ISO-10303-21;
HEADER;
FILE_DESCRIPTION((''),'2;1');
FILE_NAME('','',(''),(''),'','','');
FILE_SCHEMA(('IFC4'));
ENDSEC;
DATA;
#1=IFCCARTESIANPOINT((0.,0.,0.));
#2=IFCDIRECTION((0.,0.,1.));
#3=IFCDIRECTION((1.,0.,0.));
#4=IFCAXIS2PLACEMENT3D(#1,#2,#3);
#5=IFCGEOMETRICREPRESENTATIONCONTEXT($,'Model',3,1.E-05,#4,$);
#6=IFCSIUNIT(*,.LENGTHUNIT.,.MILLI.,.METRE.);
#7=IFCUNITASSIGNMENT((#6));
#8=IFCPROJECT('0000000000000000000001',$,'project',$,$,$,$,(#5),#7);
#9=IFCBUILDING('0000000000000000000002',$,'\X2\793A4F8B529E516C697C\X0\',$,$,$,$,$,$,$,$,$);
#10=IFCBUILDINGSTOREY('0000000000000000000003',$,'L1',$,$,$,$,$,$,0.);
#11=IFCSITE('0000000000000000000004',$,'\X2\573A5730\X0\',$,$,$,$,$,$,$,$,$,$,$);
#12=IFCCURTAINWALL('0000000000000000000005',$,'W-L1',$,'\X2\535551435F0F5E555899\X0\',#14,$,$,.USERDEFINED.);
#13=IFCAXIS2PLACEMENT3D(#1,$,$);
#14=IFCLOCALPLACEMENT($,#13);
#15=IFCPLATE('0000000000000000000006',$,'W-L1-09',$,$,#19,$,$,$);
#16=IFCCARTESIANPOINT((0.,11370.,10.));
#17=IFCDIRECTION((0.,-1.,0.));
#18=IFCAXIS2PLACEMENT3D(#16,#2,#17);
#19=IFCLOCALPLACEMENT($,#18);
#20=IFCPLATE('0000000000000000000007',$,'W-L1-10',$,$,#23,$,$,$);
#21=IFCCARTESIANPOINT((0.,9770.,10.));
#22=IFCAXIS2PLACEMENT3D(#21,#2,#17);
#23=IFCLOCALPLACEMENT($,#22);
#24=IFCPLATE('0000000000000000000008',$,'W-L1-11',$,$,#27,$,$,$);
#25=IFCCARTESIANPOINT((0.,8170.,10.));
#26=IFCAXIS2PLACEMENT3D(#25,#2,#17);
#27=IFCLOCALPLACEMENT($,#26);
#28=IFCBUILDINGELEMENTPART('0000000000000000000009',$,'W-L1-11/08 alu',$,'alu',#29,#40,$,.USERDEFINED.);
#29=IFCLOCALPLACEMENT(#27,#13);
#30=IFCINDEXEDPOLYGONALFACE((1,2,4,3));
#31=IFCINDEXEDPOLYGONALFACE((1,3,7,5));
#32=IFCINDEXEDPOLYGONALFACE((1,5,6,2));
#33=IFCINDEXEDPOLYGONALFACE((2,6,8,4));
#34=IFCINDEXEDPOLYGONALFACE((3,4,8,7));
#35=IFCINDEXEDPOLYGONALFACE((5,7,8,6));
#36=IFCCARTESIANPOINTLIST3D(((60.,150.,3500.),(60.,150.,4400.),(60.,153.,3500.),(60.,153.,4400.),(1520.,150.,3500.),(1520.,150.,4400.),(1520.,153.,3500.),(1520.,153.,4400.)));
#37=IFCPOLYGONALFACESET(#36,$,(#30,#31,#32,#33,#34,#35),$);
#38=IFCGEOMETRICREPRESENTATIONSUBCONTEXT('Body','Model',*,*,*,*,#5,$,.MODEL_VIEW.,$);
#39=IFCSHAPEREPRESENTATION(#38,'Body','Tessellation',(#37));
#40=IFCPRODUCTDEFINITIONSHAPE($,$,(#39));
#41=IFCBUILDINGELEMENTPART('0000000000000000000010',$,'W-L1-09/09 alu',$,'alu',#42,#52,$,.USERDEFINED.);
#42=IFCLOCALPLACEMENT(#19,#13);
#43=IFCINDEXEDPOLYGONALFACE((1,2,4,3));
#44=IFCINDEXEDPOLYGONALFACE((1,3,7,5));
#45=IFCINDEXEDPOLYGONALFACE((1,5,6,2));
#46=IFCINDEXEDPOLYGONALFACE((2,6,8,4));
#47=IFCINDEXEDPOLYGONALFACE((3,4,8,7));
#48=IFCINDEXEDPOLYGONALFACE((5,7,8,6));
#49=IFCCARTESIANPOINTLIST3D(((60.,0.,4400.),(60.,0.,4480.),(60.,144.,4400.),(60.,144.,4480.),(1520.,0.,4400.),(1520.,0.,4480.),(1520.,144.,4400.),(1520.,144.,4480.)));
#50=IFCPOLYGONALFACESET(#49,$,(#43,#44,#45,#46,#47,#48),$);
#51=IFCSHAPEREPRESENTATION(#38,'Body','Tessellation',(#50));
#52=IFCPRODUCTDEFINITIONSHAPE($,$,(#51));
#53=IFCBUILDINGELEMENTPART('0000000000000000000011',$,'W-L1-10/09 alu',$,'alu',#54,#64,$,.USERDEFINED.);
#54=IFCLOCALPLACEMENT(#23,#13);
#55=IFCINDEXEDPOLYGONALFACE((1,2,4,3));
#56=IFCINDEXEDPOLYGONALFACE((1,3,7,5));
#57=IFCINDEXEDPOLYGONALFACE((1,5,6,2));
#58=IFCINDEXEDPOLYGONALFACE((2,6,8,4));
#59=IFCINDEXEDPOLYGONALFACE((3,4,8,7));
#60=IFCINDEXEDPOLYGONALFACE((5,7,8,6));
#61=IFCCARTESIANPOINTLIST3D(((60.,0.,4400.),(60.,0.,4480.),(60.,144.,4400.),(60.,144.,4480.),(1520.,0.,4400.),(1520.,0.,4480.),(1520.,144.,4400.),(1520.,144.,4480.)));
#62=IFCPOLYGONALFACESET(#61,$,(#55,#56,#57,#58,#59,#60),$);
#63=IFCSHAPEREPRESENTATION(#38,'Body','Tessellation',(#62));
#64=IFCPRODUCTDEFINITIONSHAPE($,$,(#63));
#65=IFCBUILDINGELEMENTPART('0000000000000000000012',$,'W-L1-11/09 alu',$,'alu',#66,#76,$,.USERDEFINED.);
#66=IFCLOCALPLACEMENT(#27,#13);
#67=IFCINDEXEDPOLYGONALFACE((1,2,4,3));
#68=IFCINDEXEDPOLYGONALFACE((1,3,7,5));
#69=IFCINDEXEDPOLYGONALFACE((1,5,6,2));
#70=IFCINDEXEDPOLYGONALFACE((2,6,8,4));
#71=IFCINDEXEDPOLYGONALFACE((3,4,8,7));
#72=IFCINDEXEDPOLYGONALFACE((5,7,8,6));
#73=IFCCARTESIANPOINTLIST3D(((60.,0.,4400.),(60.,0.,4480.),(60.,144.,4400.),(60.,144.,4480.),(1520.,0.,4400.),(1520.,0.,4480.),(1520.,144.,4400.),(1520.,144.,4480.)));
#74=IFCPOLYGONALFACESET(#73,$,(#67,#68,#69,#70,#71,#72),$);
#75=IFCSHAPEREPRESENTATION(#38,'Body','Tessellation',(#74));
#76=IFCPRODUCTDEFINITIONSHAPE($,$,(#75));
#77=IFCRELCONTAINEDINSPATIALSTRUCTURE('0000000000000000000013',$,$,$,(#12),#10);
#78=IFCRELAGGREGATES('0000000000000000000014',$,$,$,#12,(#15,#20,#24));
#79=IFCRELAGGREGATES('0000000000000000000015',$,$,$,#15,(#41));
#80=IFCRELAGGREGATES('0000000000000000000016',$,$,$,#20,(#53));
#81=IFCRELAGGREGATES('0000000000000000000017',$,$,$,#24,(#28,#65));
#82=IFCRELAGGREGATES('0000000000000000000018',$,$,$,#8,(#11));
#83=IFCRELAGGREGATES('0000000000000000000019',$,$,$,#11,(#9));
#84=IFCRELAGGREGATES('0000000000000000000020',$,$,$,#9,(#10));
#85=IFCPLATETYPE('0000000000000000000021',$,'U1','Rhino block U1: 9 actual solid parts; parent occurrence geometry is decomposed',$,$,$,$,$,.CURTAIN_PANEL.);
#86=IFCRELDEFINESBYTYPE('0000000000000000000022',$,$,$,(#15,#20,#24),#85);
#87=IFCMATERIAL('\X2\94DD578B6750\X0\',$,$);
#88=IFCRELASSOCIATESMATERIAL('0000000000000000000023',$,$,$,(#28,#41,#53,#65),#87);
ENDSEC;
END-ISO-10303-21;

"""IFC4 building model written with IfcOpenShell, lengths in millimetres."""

from ifc_helpers import new_model, si_unit, frame, frame_2d, origin, origin_with_axes, place, context, subcontext, project, spatial, rectangle, extrude, source, transform, mapped, material, type_object, element, aggregate, save


model = new_model("IFC4")

# Units and contexts
model_context = context("Model", 3, precision=1e-05, world=origin_with_axes())
body_context = subcontext(model_context, "Body", "Model", "MODEL_VIEW")
ifc_project = project(units=[si_unit("LENGTHUNIT", "METRE", prefix="MILLI")], contexts=[model_context])

# Site, building, storey
site = spatial("IfcSite", under=ifc_project, Name="场地")
building = spatial("IfcBuilding", under=site, Name="示例办公楼")
storey = spatial("IfcBuildingStorey", under=building, Name="L1", Elevation=0.0)

# Curtain wall, plates, building element parts
curtain_wall = element("IfcCurtainWall", 1, inside=storey, Name="W-L1", ObjectType="单元式幕墙", PredefinedType="USERDEFINED")
plate_type = type_object("IfcPlateType", Name="U1", Description="Rhino block U1: 9 actual solid parts; parent occurrence geometry is decomposed", PredefinedType="CURTAIN_PANEL")
ifc_material_1 = material(Name="铝型材")
plate_1_placement = place(None, frame((0.0, 11370.0, 10.0), z_axis=(0.0, 0.0, 1.0), x_axis=(0.0, -1.0, 0.0)))
plate_1 = element("IfcPlate", 2, at=plate_1_placement, type_object=plate_type, Name="W-L1-09")
plate_2_placement = place(None, frame((0.0, 9770.0, 10.0), z_axis=(0.0, 0.0, 1.0), x_axis=(0.0, -1.0, 0.0)))
plate_2 = element("IfcPlate", 3, at=plate_2_placement, type_object=plate_type, Name="W-L1-10")
plate_3_placement = place(None, frame((0.0, 8170.0, 10.0), z_axis=(0.0, 0.0, 1.0), x_axis=(0.0, -1.0, 0.0)))
plate_3 = element("IfcPlate", 4, at=plate_3_placement, type_object=plate_type, Name="W-L1-11")
aggregate(curtain_wall, [plate_1, plate_2, plate_3])
shared_shape_1 = source(origin(), body_context, "Body", "SweptSolid", [
    extrude(rectangle(XDim=1460.0, YDim=3.0, at=frame_2d((790.0, 151.5))), frame((0.0, 0.0, 3500.0)), (0.0, 0.0, 1.0), 900.0),
])
building_element_part_1_placement = place(plate_3_placement, origin())
building_element_part_1 = element("IfcBuildingElementPart", 5, at=building_element_part_1_placement, material=ifc_material_1, Name="W-L1-11/08 alu", ObjectType="alu", PredefinedType="USERDEFINED", context=body_context, shape_type="MappedRepresentation", body=[
    mapped(shared_shape_1, transform((0.0, 0.0, 0.0))),
])
shared_shape_2 = source(origin(), body_context, "Body", "SweptSolid", [
    extrude(rectangle(XDim=1460.0, YDim=144.0, at=frame_2d((790.0, 72.0))), frame((0.0, 0.0, 4400.0)), (0.0, 0.0, 1.0), 80.0),
])
building_element_part_2_placement = place(plate_1_placement, origin())
building_element_part_2 = element("IfcBuildingElementPart", 6, at=building_element_part_2_placement, material=ifc_material_1, Name="W-L1-09/09 alu", ObjectType="alu", PredefinedType="USERDEFINED", context=body_context, shape_type="MappedRepresentation", body=[
    mapped(shared_shape_2, transform((0.0, 0.0, 0.0))),
])
aggregate(plate_1, [building_element_part_2])
building_element_part_3_placement = place(plate_2_placement, origin())
building_element_part_3 = element("IfcBuildingElementPart", 7, at=building_element_part_3_placement, material=ifc_material_1, Name="W-L1-10/09 alu", ObjectType="alu", PredefinedType="USERDEFINED", context=body_context, shape_type="MappedRepresentation", body=[
    mapped(shared_shape_2, transform((0.0, 0.0, 0.0))),
])
aggregate(plate_2, [building_element_part_3])
building_element_part_4_placement = place(plate_3_placement, origin())
building_element_part_4 = element("IfcBuildingElementPart", 8, at=building_element_part_4_placement, material=ifc_material_1, Name="W-L1-11/09 alu", ObjectType="alu", PredefinedType="USERDEFINED", context=body_context, shape_type="MappedRepresentation", body=[
    mapped(shared_shape_2, transform((0.0, 0.0, 0.0))),
])
aggregate(plate_3, [building_element_part_1, building_element_part_4])

save(model, "model.ifc")
